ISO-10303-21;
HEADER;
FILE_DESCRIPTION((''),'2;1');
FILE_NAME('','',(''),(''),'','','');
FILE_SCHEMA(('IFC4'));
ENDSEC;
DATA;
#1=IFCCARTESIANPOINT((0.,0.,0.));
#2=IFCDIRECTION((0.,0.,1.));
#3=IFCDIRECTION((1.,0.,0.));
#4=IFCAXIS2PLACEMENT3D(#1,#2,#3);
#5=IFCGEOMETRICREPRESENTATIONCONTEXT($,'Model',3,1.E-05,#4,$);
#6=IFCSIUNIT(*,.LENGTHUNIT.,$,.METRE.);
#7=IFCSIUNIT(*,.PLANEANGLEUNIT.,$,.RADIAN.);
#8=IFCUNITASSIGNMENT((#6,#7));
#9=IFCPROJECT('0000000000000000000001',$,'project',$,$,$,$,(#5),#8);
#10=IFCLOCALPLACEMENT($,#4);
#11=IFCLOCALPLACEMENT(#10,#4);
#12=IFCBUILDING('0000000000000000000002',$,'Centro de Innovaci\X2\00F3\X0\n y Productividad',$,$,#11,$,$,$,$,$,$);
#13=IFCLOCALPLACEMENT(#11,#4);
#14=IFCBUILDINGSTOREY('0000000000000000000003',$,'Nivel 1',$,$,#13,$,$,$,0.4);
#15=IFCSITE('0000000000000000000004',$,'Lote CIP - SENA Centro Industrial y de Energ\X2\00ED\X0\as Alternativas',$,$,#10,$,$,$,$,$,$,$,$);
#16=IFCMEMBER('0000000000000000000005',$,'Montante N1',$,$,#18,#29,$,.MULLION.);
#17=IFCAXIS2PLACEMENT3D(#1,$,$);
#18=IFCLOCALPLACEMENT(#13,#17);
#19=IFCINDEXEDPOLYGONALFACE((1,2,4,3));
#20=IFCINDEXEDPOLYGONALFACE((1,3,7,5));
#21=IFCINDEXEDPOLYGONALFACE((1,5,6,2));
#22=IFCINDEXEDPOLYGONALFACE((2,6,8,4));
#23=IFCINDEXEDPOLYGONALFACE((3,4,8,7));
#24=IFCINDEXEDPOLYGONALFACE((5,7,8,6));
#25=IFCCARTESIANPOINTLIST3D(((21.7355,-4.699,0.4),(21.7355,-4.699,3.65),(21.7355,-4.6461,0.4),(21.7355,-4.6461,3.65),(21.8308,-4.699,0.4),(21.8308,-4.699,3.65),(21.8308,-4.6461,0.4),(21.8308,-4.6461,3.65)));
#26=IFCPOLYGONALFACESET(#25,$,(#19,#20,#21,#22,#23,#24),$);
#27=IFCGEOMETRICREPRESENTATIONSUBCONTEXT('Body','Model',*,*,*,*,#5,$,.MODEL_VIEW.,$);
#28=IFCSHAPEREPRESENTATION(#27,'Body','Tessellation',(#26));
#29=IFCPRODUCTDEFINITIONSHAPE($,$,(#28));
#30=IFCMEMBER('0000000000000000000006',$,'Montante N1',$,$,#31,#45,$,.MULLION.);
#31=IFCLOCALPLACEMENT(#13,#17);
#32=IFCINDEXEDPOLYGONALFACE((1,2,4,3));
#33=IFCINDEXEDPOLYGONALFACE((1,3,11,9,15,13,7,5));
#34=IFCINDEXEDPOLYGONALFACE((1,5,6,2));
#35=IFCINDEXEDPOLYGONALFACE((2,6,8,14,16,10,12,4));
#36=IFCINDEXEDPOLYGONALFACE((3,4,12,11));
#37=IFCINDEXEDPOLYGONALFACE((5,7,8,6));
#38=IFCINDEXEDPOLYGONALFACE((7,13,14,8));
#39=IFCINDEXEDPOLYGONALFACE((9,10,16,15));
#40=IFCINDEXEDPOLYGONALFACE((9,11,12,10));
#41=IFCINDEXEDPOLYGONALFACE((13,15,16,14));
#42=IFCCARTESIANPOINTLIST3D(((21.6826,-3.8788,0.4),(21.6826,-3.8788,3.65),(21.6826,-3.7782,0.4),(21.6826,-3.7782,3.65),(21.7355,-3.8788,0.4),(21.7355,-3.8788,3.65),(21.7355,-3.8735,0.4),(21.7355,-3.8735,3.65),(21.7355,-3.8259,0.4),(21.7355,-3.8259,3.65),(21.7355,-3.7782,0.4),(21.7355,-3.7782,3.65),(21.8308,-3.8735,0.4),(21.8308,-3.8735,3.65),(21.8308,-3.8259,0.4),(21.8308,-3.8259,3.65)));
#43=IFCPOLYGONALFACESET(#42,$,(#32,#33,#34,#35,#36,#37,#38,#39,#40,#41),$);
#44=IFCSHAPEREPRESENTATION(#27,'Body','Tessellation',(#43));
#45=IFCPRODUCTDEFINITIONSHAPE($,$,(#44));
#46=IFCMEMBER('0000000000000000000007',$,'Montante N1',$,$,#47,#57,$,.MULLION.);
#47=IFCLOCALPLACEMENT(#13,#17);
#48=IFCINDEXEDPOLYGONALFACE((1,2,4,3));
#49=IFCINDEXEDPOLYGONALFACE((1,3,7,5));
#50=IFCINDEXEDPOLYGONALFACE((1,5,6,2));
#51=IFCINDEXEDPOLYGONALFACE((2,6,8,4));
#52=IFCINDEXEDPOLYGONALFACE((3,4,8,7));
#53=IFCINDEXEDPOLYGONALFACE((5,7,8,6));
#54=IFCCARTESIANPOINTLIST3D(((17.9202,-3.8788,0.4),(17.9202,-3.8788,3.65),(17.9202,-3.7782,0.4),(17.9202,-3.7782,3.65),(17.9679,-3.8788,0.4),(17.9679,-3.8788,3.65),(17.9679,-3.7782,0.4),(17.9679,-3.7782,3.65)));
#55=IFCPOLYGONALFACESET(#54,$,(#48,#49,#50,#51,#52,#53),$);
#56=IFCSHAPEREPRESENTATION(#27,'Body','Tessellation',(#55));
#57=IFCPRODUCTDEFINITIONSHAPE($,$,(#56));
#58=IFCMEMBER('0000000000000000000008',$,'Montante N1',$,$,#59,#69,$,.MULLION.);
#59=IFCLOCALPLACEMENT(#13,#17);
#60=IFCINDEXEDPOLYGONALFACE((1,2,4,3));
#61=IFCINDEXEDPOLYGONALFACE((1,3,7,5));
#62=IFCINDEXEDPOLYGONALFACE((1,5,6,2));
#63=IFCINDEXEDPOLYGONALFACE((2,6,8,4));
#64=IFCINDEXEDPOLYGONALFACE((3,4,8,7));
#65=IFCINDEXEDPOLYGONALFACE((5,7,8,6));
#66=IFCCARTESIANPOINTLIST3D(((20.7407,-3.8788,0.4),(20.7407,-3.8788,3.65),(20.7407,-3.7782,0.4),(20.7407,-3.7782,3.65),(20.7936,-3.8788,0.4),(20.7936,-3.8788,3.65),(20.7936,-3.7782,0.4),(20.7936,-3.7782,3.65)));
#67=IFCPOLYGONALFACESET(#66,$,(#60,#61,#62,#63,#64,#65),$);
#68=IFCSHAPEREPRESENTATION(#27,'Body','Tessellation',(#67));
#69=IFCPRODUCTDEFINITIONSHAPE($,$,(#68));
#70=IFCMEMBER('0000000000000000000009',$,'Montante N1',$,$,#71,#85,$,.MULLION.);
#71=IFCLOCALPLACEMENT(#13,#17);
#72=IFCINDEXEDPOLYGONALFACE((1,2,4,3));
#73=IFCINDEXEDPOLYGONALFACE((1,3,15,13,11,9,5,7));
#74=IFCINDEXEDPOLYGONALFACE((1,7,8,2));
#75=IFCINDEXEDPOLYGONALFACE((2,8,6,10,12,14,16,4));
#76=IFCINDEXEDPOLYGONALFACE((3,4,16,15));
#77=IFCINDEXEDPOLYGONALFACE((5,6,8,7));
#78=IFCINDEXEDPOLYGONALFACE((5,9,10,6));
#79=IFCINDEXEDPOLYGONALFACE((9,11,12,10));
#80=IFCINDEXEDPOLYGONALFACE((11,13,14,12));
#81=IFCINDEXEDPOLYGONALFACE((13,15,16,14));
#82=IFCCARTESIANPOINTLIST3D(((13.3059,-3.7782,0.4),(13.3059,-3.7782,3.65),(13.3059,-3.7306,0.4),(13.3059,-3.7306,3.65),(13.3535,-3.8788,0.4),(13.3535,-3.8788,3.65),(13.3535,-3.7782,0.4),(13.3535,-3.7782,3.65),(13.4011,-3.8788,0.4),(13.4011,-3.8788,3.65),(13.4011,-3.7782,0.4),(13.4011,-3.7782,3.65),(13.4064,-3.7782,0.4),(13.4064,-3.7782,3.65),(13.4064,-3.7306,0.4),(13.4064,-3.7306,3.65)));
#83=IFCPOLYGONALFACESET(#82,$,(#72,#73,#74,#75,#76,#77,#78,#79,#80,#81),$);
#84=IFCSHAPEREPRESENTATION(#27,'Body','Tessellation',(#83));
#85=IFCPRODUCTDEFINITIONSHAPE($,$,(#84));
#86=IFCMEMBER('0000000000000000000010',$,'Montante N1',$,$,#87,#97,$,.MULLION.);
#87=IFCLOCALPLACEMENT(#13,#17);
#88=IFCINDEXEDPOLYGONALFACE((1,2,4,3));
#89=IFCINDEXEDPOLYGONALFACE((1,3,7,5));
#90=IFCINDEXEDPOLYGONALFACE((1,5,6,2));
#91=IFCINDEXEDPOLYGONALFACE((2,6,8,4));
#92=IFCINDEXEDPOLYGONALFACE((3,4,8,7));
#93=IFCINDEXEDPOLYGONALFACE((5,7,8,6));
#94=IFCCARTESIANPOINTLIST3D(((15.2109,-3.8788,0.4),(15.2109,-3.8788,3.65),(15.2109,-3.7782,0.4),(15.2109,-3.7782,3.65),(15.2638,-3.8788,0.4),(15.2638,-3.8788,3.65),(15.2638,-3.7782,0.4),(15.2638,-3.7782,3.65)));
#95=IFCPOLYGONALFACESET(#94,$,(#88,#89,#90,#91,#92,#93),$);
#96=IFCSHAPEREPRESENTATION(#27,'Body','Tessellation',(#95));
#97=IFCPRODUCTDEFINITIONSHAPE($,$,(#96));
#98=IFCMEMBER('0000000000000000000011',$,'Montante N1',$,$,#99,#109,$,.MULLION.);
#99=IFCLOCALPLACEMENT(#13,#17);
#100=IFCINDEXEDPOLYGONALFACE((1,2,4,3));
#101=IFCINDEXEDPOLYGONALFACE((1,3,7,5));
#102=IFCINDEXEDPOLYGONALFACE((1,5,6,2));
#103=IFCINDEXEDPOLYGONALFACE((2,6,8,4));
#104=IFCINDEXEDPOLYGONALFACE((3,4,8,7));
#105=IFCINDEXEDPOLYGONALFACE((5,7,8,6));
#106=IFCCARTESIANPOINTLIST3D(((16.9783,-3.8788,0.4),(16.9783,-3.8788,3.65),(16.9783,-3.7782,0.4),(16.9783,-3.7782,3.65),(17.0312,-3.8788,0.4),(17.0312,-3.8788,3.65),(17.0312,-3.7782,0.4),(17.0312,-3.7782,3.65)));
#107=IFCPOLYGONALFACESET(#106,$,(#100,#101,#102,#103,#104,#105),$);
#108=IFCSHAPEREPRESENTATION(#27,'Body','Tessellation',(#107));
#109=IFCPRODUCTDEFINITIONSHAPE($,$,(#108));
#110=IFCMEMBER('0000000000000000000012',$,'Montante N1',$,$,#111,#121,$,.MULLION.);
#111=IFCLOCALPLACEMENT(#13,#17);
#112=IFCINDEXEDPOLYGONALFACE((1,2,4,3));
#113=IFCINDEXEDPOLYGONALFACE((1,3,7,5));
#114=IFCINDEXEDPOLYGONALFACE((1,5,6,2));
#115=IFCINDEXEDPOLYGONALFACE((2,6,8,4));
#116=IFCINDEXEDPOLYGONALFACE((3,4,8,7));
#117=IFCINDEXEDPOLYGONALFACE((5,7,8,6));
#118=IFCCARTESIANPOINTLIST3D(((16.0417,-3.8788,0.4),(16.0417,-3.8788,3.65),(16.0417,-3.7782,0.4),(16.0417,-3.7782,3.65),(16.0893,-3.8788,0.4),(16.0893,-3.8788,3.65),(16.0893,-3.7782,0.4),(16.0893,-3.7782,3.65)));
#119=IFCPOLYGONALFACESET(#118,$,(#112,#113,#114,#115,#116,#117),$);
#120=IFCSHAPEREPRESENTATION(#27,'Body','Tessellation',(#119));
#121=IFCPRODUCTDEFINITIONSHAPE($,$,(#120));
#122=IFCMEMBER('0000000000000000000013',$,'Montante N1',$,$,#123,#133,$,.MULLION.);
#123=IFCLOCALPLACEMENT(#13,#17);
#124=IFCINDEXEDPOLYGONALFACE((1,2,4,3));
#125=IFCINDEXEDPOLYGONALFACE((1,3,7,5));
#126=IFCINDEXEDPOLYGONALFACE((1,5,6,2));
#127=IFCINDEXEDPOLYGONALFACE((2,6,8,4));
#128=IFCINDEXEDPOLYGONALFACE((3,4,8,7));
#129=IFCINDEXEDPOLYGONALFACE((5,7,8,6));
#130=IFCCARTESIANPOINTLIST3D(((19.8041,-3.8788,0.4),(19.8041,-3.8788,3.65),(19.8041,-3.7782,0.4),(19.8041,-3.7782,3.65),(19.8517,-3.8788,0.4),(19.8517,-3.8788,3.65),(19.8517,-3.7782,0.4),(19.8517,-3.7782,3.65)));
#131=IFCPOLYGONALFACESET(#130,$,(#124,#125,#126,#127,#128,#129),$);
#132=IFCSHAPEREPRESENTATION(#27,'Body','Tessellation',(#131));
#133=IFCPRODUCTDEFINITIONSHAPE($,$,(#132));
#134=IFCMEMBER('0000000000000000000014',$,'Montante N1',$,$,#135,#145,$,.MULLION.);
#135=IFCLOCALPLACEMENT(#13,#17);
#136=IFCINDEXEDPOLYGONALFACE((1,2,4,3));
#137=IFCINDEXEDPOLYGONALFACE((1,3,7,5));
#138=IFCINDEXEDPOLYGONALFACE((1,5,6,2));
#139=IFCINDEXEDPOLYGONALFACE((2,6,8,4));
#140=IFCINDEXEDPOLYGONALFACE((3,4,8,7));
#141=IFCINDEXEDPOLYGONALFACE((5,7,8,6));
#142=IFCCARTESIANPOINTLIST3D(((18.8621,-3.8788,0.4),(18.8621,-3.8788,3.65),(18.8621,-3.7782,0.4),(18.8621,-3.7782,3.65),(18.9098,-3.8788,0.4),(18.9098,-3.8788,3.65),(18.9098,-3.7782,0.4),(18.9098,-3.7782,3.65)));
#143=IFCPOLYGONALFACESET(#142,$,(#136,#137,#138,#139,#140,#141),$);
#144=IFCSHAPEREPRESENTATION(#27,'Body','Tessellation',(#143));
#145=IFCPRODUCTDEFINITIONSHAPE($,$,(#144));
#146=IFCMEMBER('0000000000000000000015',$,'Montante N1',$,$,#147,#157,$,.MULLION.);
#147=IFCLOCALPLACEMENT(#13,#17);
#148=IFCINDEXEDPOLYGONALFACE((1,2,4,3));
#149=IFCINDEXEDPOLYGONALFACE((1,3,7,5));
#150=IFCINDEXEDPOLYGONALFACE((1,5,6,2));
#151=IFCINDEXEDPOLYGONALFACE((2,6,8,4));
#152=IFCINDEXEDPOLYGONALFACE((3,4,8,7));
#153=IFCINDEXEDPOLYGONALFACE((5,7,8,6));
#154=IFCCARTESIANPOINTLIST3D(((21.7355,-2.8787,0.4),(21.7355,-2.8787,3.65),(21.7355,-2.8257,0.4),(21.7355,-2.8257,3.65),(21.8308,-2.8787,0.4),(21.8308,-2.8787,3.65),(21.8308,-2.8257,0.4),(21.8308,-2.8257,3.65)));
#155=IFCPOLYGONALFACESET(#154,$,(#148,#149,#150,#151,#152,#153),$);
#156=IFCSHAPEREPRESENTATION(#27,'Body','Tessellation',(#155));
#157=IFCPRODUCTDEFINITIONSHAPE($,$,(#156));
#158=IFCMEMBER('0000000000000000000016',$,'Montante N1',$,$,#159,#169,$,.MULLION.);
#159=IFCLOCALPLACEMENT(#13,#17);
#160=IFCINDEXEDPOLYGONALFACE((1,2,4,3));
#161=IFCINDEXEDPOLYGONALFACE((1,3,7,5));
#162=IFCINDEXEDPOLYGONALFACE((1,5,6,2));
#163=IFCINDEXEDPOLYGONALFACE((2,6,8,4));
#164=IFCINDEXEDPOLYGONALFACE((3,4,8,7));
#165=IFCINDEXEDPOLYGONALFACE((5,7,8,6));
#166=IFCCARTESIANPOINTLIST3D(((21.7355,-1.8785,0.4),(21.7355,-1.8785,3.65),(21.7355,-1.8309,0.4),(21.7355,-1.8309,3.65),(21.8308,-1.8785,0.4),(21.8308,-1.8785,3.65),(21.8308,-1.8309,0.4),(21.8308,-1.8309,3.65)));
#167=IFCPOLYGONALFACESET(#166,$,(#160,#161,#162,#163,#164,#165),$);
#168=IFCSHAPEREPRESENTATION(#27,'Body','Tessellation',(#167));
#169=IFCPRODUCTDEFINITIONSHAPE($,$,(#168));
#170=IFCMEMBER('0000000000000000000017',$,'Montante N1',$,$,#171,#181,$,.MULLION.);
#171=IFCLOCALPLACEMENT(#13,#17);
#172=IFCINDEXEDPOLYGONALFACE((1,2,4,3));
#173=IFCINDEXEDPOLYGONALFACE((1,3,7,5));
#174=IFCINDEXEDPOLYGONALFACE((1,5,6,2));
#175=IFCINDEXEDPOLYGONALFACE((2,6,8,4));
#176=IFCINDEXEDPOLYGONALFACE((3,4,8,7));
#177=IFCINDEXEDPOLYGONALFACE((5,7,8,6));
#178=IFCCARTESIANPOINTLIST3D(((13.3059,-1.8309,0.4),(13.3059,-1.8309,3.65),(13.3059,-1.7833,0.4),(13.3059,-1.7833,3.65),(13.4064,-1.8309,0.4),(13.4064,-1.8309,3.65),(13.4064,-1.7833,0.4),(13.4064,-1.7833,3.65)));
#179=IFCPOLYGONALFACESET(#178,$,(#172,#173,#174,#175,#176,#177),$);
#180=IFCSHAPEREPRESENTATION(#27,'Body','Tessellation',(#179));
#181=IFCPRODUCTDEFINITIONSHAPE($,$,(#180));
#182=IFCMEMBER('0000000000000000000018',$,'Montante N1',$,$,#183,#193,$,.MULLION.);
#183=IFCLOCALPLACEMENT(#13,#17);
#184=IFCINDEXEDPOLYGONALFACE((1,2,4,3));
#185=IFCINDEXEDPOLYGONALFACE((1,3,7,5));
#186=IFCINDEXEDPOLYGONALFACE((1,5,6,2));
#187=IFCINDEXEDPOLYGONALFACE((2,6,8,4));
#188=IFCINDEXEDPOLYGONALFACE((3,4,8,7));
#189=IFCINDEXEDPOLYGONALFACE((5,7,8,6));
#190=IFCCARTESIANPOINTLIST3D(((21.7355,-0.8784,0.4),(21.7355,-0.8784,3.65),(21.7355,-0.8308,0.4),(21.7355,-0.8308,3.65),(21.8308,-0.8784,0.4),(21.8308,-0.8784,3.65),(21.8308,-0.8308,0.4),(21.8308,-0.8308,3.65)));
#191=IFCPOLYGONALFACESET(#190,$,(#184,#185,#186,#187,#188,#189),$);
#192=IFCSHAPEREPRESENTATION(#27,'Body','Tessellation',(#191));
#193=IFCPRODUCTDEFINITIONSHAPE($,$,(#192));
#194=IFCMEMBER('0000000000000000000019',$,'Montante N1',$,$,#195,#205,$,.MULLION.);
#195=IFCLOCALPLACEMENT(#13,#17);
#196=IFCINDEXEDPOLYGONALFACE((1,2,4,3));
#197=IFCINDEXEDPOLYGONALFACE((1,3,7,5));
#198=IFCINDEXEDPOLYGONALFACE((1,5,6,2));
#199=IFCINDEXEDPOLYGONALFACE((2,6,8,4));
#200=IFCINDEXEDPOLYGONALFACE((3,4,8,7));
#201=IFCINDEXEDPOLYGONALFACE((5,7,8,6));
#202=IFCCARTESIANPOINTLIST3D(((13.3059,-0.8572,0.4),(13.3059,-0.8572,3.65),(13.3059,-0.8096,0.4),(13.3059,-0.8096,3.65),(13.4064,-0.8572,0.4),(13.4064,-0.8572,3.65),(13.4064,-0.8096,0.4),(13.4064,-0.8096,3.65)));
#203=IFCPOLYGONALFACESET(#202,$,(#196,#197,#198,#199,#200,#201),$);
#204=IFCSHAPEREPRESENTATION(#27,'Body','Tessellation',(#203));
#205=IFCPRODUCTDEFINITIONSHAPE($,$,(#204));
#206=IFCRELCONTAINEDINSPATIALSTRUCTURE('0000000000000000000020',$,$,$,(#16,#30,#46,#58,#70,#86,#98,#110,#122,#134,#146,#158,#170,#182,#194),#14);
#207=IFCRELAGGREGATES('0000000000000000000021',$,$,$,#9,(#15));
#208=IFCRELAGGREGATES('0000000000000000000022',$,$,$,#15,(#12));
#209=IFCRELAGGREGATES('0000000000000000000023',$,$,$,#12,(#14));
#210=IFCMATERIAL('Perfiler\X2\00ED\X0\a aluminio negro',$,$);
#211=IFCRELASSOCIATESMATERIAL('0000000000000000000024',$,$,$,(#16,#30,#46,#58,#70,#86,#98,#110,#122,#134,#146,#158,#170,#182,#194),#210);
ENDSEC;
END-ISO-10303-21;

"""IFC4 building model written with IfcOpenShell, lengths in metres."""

from ifc_helpers import new_model, si_unit, frame, origin_with_axes, place, context, subcontext, project, spatial, polyline, outline, extrude, material, element, save


model = new_model("IFC4")

# Units and contexts
model_context = context("Model", 3, precision=1e-05, world=origin_with_axes())
body_context = subcontext(model_context, "Body", "Model", "MODEL_VIEW")
ifc_project = project(units=[si_unit("LENGTHUNIT", "METRE"), si_unit("PLANEANGLEUNIT", "RADIAN")], contexts=[model_context])

# Site, building, storey
site_placement = place(None, origin_with_axes())
site = spatial("IfcSite", under=ifc_project, at=site_placement, Name="Lote CIP - SENA Centro Industrial y de Energías Alternativas")
building_placement = place(site_placement, origin_with_axes())
building = spatial("IfcBuilding", under=site, at=building_placement, Name="Centro de Innovación y Productividad")
storey_placement = place(building_placement, origin_with_axes())
storey = spatial("IfcBuildingStorey", under=building, at=storey_placement, Name="Nivel 1", Elevation=0.4)

# Members
ifc_material = material(Name="Perfilería aluminio negro")
member_1_placement = place(storey_placement, origin_with_axes())
element("IfcMember", 1, at=member_1_placement, inside=storey, material=ifc_material, Name="Montante N1", PredefinedType="MULLION", context=body_context, shape_type="SweptSolid", body=[
    extrude(outline(polyline([(21.7355, -4.699), (21.7355, -4.6461), (21.8308, -4.6461), (21.8308, -4.699), (21.7355, -4.699)])), frame((0.0, 0.0, 0.4)), (0.0, 0.0, 1.0), 3.25),
])
member_2_placement = place(storey_placement, origin_with_axes())
element("IfcMember", 2, at=member_2_placement, inside=storey, material=ifc_material, Name="Montante N1", PredefinedType="MULLION", context=body_context, shape_type="SweptSolid", body=[
    extrude(outline(polyline([(21.7355, -3.7782), (21.7355, -3.8259), (21.8308, -3.8259), (21.8308, -3.8735), (21.7355, -3.8735), (21.7355, -3.8788), (21.6826, -3.8788), (21.6826, -3.7782), (21.7355, -3.7782)])), frame((0.0, 0.0, 0.4)), (0.0, 0.0, 1.0), 3.25),
])
member_3_placement = place(storey_placement, origin_with_axes())
element("IfcMember", 3, at=member_3_placement, inside=storey, material=ifc_material, Name="Montante N1", PredefinedType="MULLION", context=body_context, shape_type="SweptSolid", body=[
    extrude(outline(polyline([(17.9679, -3.8788), (17.9202, -3.8788), (17.9202, -3.7782), (17.9679, -3.7782), (17.9679, -3.8788)])), frame((0.0, 0.0, 0.4)), (0.0, 0.0, 1.0), 3.25),
])
member_4_placement = place(storey_placement, origin_with_axes())
element("IfcMember", 4, at=member_4_placement, inside=storey, material=ifc_material, Name="Montante N1", PredefinedType="MULLION", context=body_context, shape_type="SweptSolid", body=[
    extrude(outline(polyline([(20.7936, -3.7782), (20.7936, -3.8788), (20.7407, -3.8788), (20.7407, -3.7782), (20.7936, -3.7782)])), frame((0.0, 0.0, 0.4)), (0.0, 0.0, 1.0), 3.25),
])
member_5_placement = place(storey_placement, origin_with_axes())
element("IfcMember", 5, at=member_5_placement, inside=storey, material=ifc_material, Name="Montante N1", PredefinedType="MULLION", context=body_context, shape_type="SweptSolid", body=[
    extrude(outline(polyline([(13.4064, -3.7782), (13.4011, -3.7782), (13.4011, -3.8788), (13.3535, -3.8788), (13.3535, -3.7782), (13.3059, -3.7782), (13.3059, -3.7306), (13.4064, -3.7306), (13.4064, -3.7782)])), frame((0.0, 0.0, 0.4)), (0.0, 0.0, 1.0), 3.25),
])
member_6_placement = place(storey_placement, origin_with_axes())
element("IfcMember", 6, at=member_6_placement, inside=storey, material=ifc_material, Name="Montante N1", PredefinedType="MULLION", context=body_context, shape_type="SweptSolid", body=[
    extrude(outline(polyline([(15.2638, -3.7782), (15.2638, -3.8788), (15.2109, -3.8788), (15.2109, -3.7782), (15.2638, -3.7782)])), frame((0.0, 0.0, 0.4)), (0.0, 0.0, 1.0), 3.25),
])
member_7_placement = place(storey_placement, origin_with_axes())
element("IfcMember", 7, at=member_7_placement, inside=storey, material=ifc_material, Name="Montante N1", PredefinedType="MULLION", context=body_context, shape_type="SweptSolid", body=[
    extrude(outline(polyline([(17.0312, -3.7782), (17.0312, -3.8788), (16.9783, -3.8788), (16.9783, -3.7782), (17.0312, -3.7782)])), frame((0.0, 0.0, 0.4)), (0.0, 0.0, 1.0), 3.25),
])
member_8_placement = place(storey_placement, origin_with_axes())
element("IfcMember", 8, at=member_8_placement, inside=storey, material=ifc_material, Name="Montante N1", PredefinedType="MULLION", context=body_context, shape_type="SweptSolid", body=[
    extrude(outline(polyline([(16.0417, -3.7782), (16.0893, -3.7782), (16.0893, -3.8788), (16.0417, -3.8788), (16.0417, -3.7782)])), frame((0.0, 0.0, 0.4)), (0.0, 0.0, 1.0), 3.25),
])
member_9_placement = place(storey_placement, origin_with_axes())
element("IfcMember", 9, at=member_9_placement, inside=storey, material=ifc_material, Name="Montante N1", PredefinedType="MULLION", context=body_context, shape_type="SweptSolid", body=[
    extrude(outline(polyline([(19.8517, -3.8788), (19.8041, -3.8788), (19.8041, -3.7782), (19.8517, -3.7782), (19.8517, -3.8788)])), frame((0.0, 0.0, 0.4)), (0.0, 0.0, 1.0), 3.25),
])
member_10_placement = place(storey_placement, origin_with_axes())
element("IfcMember", 10, at=member_10_placement, inside=storey, material=ifc_material, Name="Montante N1", PredefinedType="MULLION", context=body_context, shape_type="SweptSolid", body=[
    extrude(outline(polyline([(18.9098, -3.8788), (18.8621, -3.8788), (18.8621, -3.7782), (18.9098, -3.7782), (18.9098, -3.8788)])), frame((0.0, 0.0, 0.4)), (0.0, 0.0, 1.0), 3.25),
])
member_11_placement = place(storey_placement, origin_with_axes())
element("IfcMember", 11, at=member_11_placement, inside=storey, material=ifc_material, Name="Montante N1", PredefinedType="MULLION", context=body_context, shape_type="SweptSolid", body=[
    extrude(outline(polyline([(21.8308, -2.8787), (21.7355, -2.8787), (21.7355, -2.8257), (21.8308, -2.8257), (21.8308, -2.8787)])), frame((0.0, 0.0, 0.4)), (0.0, 0.0, 1.0), 3.25),
])
member_12_placement = place(storey_placement, origin_with_axes())
element("IfcMember", 12, at=member_12_placement, inside=storey, material=ifc_material, Name="Montante N1", PredefinedType="MULLION", context=body_context, shape_type="SweptSolid", body=[
    extrude(outline(polyline([(21.8308, -1.8309), (21.8308, -1.8785), (21.7355, -1.8785), (21.7355, -1.8309), (21.8308, -1.8309)])), frame((0.0, 0.0, 0.4)), (0.0, 0.0, 1.0), 3.25),
])
member_13_placement = place(storey_placement, origin_with_axes())
element("IfcMember", 13, at=member_13_placement, inside=storey, material=ifc_material, Name="Montante N1", PredefinedType="MULLION", context=body_context, shape_type="SweptSolid", body=[
    extrude(outline(polyline([(13.3059, -1.7833), (13.4064, -1.7833), (13.4064, -1.8309), (13.3059, -1.8309), (13.3059, -1.7833)])), frame((0.0, 0.0, 0.4)), (0.0, 0.0, 1.0), 3.25),
])
member_14_placement = place(storey_placement, origin_with_axes())
element("IfcMember", 14, at=member_14_placement, inside=storey, material=ifc_material, Name="Montante N1", PredefinedType="MULLION", context=body_context, shape_type="SweptSolid", body=[
    extrude(outline(polyline([(21.8308, -0.8784), (21.7355, -0.8784), (21.7355, -0.8308), (21.8308, -0.8308), (21.8308, -0.8784)])), frame((0.0, 0.0, 0.4)), (0.0, 0.0, 1.0), 3.25),
])
member_15_placement = place(storey_placement, origin_with_axes())
element("IfcMember", 15, at=member_15_placement, inside=storey, material=ifc_material, Name="Montante N1", PredefinedType="MULLION", context=body_context, shape_type="SweptSolid", body=[
    extrude(outline(polyline([(13.3059, -0.8096), (13.4064, -0.8096), (13.4064, -0.8572), (13.3059, -0.8572), (13.3059, -0.8096)])), frame((0.0, 0.0, 0.4)), (0.0, 0.0, 1.0), 3.25),
])

save(model, "model.ifc")
